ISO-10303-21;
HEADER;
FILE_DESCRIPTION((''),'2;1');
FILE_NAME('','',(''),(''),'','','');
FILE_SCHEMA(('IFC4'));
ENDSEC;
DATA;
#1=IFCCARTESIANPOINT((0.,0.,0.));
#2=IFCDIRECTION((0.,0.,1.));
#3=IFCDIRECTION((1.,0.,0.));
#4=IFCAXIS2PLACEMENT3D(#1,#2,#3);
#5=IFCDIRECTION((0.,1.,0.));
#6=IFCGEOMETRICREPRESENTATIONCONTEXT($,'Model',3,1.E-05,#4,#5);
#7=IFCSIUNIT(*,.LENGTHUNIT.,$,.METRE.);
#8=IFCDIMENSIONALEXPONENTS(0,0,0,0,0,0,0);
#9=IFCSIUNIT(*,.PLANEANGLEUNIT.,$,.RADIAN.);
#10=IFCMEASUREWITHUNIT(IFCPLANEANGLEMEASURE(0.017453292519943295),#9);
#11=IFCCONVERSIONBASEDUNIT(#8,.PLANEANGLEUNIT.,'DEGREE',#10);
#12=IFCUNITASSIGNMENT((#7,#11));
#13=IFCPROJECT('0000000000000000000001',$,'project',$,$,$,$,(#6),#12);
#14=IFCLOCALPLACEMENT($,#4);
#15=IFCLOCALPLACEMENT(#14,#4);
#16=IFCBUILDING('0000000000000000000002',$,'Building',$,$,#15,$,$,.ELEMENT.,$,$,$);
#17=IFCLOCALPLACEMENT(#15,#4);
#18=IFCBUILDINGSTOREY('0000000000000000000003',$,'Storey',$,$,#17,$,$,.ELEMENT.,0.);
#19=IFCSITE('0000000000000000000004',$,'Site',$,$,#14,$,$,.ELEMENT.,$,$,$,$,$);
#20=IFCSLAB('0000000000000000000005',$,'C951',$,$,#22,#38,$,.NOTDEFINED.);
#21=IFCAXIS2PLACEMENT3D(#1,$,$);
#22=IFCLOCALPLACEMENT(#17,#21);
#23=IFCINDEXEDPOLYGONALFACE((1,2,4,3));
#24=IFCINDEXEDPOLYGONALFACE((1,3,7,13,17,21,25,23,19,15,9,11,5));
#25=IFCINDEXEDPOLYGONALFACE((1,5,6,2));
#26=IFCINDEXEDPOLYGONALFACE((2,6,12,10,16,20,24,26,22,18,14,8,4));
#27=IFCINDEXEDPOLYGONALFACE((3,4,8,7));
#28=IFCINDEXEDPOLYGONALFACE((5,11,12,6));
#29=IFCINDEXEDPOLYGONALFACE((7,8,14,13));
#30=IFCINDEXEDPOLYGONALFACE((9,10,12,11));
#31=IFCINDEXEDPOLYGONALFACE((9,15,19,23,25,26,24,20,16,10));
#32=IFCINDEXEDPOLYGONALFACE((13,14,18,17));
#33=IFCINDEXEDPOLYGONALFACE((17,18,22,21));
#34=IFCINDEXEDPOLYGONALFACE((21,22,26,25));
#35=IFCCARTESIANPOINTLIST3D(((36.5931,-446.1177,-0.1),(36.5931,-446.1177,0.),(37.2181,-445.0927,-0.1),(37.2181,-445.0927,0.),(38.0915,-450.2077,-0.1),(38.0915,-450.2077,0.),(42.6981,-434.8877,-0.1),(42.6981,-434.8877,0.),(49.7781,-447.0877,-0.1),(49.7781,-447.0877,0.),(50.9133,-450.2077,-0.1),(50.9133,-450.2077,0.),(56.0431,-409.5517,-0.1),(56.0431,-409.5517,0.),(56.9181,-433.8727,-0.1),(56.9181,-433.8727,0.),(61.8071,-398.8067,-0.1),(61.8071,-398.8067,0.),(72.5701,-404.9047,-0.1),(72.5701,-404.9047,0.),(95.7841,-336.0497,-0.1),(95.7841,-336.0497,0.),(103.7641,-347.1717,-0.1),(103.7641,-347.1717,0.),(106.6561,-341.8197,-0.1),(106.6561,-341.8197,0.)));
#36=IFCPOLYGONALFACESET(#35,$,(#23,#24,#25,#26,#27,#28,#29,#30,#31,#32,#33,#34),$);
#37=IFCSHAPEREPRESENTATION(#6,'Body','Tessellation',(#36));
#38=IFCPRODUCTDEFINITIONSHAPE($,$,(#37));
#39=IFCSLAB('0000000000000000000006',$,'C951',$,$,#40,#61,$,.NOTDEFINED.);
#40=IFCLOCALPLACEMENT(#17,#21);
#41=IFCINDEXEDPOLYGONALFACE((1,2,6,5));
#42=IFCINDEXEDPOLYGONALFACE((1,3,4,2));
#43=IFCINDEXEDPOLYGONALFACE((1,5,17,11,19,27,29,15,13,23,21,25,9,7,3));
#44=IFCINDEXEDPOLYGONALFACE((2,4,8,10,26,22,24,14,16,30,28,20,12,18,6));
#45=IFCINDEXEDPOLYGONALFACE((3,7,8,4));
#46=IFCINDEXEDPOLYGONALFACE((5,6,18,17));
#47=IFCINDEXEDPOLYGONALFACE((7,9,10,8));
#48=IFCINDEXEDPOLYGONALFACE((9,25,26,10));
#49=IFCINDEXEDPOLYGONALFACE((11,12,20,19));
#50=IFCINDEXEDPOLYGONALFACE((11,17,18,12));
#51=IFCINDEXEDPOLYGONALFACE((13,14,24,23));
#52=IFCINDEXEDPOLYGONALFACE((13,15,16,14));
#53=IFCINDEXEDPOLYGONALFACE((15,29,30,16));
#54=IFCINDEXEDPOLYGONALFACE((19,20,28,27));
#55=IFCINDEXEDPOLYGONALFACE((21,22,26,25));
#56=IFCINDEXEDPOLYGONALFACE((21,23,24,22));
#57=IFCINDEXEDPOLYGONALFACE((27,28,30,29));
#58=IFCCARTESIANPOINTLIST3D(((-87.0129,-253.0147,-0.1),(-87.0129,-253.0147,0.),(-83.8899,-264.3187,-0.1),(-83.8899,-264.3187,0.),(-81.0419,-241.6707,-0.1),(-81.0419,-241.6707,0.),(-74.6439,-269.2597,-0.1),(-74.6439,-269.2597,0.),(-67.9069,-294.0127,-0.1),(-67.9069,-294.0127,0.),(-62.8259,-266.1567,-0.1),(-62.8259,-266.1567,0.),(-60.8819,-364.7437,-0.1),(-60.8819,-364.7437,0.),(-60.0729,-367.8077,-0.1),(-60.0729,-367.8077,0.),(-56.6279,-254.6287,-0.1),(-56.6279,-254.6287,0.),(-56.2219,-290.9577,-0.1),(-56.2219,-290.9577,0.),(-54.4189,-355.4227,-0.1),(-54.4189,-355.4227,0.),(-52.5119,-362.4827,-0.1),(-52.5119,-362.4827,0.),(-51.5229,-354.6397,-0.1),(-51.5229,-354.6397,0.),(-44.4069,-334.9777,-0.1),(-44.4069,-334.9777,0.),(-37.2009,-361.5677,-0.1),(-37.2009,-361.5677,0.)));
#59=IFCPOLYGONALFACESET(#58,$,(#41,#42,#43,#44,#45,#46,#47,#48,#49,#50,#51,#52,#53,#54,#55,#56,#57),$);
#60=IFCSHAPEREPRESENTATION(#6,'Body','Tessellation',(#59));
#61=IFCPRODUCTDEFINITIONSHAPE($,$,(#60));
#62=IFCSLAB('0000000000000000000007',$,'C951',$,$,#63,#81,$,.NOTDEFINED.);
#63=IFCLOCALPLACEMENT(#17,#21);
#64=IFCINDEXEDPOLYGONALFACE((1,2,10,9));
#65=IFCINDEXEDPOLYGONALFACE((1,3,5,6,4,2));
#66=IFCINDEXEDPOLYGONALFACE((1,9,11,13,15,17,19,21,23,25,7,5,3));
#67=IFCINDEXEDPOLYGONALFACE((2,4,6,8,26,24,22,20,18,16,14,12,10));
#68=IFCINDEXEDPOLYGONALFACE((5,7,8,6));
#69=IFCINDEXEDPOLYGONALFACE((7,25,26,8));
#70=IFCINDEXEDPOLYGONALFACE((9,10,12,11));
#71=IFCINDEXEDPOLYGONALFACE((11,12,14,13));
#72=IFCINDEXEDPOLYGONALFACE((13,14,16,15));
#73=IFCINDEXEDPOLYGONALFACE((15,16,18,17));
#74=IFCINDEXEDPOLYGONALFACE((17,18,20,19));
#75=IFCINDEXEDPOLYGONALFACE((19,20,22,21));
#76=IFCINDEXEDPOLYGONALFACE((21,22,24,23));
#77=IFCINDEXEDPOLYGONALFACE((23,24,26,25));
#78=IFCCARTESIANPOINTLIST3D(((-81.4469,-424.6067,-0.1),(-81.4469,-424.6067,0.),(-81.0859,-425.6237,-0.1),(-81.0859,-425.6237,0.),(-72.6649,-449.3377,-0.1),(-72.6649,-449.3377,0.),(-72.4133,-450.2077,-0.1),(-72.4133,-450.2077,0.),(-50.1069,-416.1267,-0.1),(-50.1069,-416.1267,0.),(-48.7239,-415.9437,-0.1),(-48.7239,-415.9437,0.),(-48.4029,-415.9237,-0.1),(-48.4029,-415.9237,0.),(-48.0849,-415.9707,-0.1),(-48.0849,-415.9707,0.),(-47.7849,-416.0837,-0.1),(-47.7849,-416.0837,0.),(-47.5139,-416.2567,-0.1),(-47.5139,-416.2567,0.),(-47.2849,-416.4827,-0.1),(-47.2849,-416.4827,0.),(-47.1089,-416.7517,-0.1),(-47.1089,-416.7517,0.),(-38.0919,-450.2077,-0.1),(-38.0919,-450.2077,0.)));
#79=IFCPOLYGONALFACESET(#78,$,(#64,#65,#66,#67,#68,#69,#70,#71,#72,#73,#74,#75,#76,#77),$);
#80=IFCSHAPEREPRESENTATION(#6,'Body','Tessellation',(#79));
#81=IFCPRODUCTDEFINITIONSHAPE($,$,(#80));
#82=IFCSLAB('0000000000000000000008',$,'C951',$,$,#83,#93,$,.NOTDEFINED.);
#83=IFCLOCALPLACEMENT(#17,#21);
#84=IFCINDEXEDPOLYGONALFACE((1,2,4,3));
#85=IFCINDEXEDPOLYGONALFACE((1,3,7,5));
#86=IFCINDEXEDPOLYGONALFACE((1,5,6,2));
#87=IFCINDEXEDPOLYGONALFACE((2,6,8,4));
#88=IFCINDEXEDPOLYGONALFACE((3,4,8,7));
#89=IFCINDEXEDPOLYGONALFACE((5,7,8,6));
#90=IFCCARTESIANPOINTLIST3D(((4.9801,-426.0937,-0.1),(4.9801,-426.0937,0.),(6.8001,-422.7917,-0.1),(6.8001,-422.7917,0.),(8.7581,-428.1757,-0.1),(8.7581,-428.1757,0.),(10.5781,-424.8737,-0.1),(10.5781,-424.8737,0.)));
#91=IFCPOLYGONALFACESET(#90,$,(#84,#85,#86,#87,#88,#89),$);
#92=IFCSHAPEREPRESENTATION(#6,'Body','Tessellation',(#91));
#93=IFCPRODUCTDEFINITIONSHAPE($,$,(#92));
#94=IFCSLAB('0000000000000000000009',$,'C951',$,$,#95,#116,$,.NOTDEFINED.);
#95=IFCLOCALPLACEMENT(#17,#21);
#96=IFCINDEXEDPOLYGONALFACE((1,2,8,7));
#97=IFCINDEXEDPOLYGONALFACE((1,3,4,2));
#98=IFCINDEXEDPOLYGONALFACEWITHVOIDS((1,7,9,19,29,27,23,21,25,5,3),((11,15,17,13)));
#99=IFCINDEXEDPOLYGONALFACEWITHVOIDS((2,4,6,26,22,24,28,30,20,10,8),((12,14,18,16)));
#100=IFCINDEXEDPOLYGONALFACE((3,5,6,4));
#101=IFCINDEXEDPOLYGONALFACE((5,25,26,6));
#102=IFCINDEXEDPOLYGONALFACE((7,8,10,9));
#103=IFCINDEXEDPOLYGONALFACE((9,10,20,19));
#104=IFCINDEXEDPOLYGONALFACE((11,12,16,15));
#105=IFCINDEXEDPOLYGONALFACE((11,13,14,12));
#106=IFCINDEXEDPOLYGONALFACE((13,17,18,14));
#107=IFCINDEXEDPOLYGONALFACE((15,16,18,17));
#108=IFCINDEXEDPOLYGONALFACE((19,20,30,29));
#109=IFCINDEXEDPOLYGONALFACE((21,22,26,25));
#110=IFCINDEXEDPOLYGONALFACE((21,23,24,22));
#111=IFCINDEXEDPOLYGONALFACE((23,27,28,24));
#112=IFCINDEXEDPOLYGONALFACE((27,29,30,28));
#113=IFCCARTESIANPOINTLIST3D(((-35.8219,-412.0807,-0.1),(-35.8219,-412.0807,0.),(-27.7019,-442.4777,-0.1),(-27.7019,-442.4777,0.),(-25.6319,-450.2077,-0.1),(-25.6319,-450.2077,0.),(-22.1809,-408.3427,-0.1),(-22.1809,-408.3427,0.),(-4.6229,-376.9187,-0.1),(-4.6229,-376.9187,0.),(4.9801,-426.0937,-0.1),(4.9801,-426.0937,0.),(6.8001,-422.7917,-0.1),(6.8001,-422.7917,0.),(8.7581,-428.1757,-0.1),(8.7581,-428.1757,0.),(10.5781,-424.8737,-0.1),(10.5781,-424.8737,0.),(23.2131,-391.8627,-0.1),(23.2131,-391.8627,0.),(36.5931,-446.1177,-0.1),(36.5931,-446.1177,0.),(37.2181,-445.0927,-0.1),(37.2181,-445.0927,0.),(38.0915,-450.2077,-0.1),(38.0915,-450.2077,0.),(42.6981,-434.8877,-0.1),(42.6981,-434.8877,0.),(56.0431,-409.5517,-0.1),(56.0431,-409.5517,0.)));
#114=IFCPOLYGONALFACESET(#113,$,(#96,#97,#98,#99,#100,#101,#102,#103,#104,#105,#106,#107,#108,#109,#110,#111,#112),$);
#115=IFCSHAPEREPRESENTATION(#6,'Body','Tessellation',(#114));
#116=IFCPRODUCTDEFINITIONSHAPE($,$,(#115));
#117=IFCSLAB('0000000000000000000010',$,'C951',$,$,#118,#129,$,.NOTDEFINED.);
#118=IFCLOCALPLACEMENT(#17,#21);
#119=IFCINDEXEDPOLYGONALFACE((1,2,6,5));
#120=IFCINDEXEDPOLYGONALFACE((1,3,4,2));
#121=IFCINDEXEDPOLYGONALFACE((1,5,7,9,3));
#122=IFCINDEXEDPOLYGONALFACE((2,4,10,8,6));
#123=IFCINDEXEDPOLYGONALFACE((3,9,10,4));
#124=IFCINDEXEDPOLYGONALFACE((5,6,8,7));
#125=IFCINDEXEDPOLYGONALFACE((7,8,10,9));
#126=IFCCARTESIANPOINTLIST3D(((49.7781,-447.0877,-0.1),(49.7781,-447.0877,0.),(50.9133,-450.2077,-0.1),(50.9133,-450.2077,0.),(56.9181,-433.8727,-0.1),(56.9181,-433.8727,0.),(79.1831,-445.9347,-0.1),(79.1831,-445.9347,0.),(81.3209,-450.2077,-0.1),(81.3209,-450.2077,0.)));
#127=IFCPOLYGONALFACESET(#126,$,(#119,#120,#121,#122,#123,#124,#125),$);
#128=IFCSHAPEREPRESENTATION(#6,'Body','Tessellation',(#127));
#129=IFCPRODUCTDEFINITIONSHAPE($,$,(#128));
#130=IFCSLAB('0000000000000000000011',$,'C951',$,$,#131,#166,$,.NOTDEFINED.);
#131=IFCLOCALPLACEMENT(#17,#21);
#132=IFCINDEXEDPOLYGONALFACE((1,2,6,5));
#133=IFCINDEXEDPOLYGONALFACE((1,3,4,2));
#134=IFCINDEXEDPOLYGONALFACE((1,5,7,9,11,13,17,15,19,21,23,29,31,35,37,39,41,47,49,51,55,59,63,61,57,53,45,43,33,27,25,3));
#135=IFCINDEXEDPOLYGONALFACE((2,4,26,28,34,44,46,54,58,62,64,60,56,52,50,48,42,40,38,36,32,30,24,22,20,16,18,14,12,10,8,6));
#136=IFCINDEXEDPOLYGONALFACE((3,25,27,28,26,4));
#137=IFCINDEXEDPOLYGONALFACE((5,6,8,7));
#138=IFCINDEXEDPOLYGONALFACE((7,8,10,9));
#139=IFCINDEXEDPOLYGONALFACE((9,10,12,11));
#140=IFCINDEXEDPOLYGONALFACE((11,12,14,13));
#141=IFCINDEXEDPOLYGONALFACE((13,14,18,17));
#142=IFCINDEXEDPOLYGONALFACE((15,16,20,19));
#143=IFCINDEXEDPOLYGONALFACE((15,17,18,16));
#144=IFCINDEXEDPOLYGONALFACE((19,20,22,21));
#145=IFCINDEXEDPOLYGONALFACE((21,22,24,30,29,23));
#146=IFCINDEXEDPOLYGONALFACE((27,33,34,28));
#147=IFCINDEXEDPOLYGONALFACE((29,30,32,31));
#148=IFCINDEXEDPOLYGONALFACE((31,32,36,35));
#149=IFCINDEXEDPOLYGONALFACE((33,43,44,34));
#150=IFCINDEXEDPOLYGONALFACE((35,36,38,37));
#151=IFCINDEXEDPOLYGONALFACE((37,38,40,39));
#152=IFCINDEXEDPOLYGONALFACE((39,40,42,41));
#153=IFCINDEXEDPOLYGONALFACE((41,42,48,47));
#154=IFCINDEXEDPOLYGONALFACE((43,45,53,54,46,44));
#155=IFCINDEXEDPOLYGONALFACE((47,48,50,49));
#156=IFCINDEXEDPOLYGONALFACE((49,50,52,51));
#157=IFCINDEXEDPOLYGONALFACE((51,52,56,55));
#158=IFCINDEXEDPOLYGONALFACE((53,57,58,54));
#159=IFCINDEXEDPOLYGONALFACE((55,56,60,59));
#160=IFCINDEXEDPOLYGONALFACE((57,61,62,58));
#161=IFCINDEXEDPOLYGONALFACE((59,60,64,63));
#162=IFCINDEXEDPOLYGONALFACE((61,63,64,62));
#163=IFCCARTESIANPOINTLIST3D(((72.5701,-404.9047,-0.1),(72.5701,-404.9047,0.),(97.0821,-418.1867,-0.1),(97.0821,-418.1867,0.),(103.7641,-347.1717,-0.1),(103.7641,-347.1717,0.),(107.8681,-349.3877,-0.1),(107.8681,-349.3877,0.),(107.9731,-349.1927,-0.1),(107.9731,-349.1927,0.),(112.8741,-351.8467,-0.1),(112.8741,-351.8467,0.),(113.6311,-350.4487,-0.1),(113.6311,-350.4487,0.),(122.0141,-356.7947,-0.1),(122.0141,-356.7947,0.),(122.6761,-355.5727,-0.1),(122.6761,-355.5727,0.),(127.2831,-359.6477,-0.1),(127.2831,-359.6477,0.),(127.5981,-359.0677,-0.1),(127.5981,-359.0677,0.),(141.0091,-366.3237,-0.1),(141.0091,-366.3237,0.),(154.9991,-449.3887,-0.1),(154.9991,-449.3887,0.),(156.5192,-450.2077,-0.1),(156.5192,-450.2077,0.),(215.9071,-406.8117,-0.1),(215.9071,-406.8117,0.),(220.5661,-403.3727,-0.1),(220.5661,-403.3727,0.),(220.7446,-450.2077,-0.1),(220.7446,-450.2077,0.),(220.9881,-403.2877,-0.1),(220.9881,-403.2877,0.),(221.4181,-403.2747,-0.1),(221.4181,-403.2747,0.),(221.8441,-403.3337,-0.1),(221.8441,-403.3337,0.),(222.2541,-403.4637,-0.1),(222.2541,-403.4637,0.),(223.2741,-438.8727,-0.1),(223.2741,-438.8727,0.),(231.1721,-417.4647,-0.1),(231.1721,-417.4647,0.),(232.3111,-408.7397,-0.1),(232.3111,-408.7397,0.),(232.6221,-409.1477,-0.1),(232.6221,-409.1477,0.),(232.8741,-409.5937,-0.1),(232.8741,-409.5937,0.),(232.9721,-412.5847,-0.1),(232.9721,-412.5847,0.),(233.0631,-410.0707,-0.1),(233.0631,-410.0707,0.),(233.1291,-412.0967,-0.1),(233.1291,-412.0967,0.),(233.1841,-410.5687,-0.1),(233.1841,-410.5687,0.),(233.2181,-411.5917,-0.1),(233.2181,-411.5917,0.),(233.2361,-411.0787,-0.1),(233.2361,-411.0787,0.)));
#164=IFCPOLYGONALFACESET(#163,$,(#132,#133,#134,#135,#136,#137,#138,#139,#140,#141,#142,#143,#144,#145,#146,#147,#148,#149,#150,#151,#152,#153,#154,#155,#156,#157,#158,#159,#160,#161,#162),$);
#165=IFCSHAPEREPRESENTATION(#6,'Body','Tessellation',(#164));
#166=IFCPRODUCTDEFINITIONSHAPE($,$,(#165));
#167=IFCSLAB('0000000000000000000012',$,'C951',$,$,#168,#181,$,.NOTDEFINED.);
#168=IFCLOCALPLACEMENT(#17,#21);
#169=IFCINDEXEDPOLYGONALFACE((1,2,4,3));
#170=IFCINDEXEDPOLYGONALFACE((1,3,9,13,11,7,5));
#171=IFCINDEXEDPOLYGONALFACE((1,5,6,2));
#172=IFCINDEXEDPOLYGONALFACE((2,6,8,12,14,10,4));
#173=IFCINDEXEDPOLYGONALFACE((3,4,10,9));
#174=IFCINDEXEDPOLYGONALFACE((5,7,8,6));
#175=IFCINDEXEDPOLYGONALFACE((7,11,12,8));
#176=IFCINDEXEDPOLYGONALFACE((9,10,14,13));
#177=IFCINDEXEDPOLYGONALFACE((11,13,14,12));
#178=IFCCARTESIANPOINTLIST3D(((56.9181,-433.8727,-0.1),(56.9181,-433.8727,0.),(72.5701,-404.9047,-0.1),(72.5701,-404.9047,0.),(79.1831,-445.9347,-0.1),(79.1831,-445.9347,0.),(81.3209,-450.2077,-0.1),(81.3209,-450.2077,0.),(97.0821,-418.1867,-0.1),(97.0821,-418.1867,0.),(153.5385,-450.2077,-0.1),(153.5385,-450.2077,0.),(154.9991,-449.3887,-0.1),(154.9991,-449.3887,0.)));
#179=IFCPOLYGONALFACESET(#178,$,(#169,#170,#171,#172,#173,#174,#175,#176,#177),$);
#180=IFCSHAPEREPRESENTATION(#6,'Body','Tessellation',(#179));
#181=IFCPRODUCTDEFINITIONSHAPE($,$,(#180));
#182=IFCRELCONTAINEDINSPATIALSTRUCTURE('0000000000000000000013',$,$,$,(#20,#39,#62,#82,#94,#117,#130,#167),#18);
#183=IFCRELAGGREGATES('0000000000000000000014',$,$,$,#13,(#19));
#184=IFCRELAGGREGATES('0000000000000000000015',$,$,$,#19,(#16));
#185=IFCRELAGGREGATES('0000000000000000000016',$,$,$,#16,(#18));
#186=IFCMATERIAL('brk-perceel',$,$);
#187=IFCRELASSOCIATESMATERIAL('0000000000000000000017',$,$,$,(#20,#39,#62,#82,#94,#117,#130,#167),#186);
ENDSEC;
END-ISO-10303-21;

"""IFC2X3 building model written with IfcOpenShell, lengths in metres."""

from ifc_helpers import new_model, entity, si_unit, converted_unit, direction, frame, origin_with_axes, place, context, project, spatial, polyline, outline, extrude, material, element, save


model = new_model("IFC2X3")

# Units and contexts
model_context = context("Model", 3, precision=1e-05, world=origin_with_axes(), true_north=direction((0.0, 1.0, 0.0)))
ifc_project = project(units=[si_unit("LENGTHUNIT", "METRE"), converted_unit("PLANEANGLEUNIT", "DEGREE", entity("IfcPlaneAngleMeasure", 0.017453292519943295), si_unit("PLANEANGLEUNIT", "RADIAN"), dimensions=[0, 0, 0, 0, 0, 0, 0])], contexts=[model_context])

# Site, building, storey
site_placement = place(None, origin_with_axes())
site = spatial("IfcSite", under=ifc_project, at=site_placement, Name="Site", CompositionType="ELEMENT")
building_placement = place(site_placement, origin_with_axes())
building = spatial("IfcBuilding", under=site, at=building_placement, Name="Building", CompositionType="ELEMENT")
storey_placement = place(building_placement, origin_with_axes())
storey = spatial("IfcBuildingStorey", under=building, at=storey_placement, Name="Storey", CompositionType="ELEMENT", Elevation=0.0)

# Slabs
ifc_material = material(Name="brk-perceel")
slab_1_placement = place(storey_placement, frame((0.0, 0.0, -0.1), z_axis=(0.0, 0.0, 1.0), x_axis=(1.0, 0.0, 0.0)))
element("IfcSlab", 1, at=slab_1_placement, inside=storey, material=ifc_material, Name="C951", PredefinedType="NOTDEFINED", context=model_context, shape_type="SweptSolid", body=[
    extrude(outline(polyline([(36.5931, -446.1177), (37.2181, -445.0927), (42.6981, -434.8877), (56.0431, -409.5517), (61.8071, -398.8067), (95.7841, -336.0497), (106.6561, -341.8197), (103.7641, -347.1717), (72.5701, -404.9047), (56.9181, -433.8727), (49.7781, -447.0877), (50.9133, -450.2077), (38.0915, -450.2077), (36.5931, -446.1177)])), origin_with_axes(), (0.0, 0.0, 1.0), 0.1),
])
slab_2_placement = place(storey_placement, frame((0.0, 0.0, -0.1), z_axis=(0.0, 0.0, 1.0), x_axis=(1.0, 0.0, 0.0)))
element("IfcSlab", 2, at=slab_2_placement, inside=storey, material=ifc_material, Name="C951", PredefinedType="NOTDEFINED", context=model_context, shape_type="SweptSolid", body=[
    extrude(outline(polyline([(-81.0419, -241.6707), (-56.6279, -254.6287), (-62.8259, -266.1567), (-56.2219, -290.9577), (-44.4069, -334.9777), (-37.2009, -361.5677), (-60.0729, -367.8077), (-60.8819, -364.7437), (-52.5119, -362.4827), (-54.4189, -355.4227), (-51.5229, -354.6397), (-67.9069, -294.0127), (-74.6439, -269.2597), (-83.8899, -264.3187), (-87.0129, -253.0147), (-81.0419, -241.6707)])), origin_with_axes(), (0.0, 0.0, 1.0), 0.1),
])
slab_3_placement = place(storey_placement, frame((0.0, 0.0, -0.1), z_axis=(0.0, 0.0, 1.0), x_axis=(1.0, 0.0, 0.0)))
element("IfcSlab", 3, at=slab_3_placement, inside=storey, material=ifc_material, Name="C951", PredefinedType="NOTDEFINED", context=model_context, shape_type="SweptSolid", body=[
    extrude(outline(polyline([(-72.6649, -449.3377), (-81.0859, -425.6237), (-81.4469, -424.6067), (-50.1069, -416.1267), (-48.7239, -415.9437), (-48.4029, -415.9237), (-48.0849, -415.9707), (-47.7849, -416.0837), (-47.5139, -416.2567), (-47.2849, -416.4827), (-47.1089, -416.7517), (-38.0919, -450.2077), (-72.4133, -450.2077), (-72.6649, -449.3377)])), origin_with_axes(), (0.0, 0.0, 1.0), 0.1),
])
slab_4_placement = place(storey_placement, frame((0.0, 0.0, -0.1), z_axis=(0.0, 0.0, 1.0), x_axis=(1.0, 0.0, 0.0)))
element("IfcSlab", 4, at=slab_4_placement, inside=storey, material=ifc_material, Name="C951", PredefinedType="NOTDEFINED", context=model_context, shape_type="SweptSolid", body=[
    extrude(outline(polyline([(8.7581, -428.1757), (4.9801, -426.0937), (6.8001, -422.7917), (10.5781, -424.8737), (8.7581, -428.1757)])), origin_with_axes(), (0.0, 0.0, 1.0), 0.1),
])
slab_5_placement = place(storey_placement, frame((0.0, 0.0, -0.1), z_axis=(0.0, 0.0, 1.0), x_axis=(1.0, 0.0, 0.0)))
element("IfcSlab", 5, at=slab_5_placement, inside=storey, material=ifc_material, Name="C951", PredefinedType="NOTDEFINED", context=model_context, shape_type="SweptSolid", body=[
    extrude(outline(polyline([(-27.7019, -442.4777), (-35.8219, -412.0807), (-22.1809, -408.3427), (-4.6229, -376.9187), (23.2131, -391.8627), (56.0431, -409.5517), (42.6981, -434.8877), (37.2181, -445.0927), (36.5931, -446.1177), (38.0915, -450.2077), (-25.6319, -450.2077), (-27.7019, -442.4777)]), holes=[polyline([(8.7581, -428.1757), (10.5781, -424.8737), (6.8001, -422.7917), (4.9801, -426.0937), (8.7581, -428.1757)])]), origin_with_axes(), (0.0, 0.0, 1.0), 0.1),
])
slab_6_placement = place(storey_placement, frame((0.0, 0.0, -0.1), z_axis=(0.0, 0.0, 1.0), x_axis=(1.0, 0.0, 0.0)))
element("IfcSlab", 6, at=slab_6_placement, inside=storey, material=ifc_material, Name="C951", PredefinedType="NOTDEFINED", context=model_context, shape_type="SweptSolid", body=[
    extrude(outline(polyline([(49.7781, -447.0877), (56.9181, -433.8727), (79.1831, -445.9347), (81.3209, -450.2077), (50.9133, -450.2077), (49.7781, -447.0877)])), origin_with_axes(), (0.0, 0.0, 1.0), 0.1),
])
slab_7_placement = place(storey_placement, frame((0.0, 0.0, -0.1), z_axis=(0.0, 0.0, 1.0), x_axis=(1.0, 0.0, 0.0)))
element("IfcSlab", 7, at=slab_7_placement, inside=storey, material=ifc_material, Name="C951", PredefinedType="NOTDEFINED", context=model_context, shape_type="SweptSolid", body=[
    extrude(outline(polyline([(154.9991, -449.3887), (97.0821, -418.1867), (72.5701, -404.9047), (103.7641, -347.1717), (107.8681, -349.3877), (107.9731, -349.1927), (112.8741, -351.8467), (113.6311, -350.4487), (122.6761, -355.5727), (122.0141, -356.7947), (127.2831, -359.6477), (127.5981, -359.0677), (141.0091, -366.3237), (215.9071, -406.8117), (220.5661, -403.3727), (220.9881, -403.2877), (221.4181, -403.2747), (221.8441, -403.3337), (222.2541, -403.4637), (232.3111, -408.7397), (232.6221, -409.1477), (232.8741, -409.5937), (233.0631, -410.0707), (233.1841, -410.5687), (233.2361, -411.0787), (233.2181, -411.5917), (233.1291, -412.0967), (232.9721, -412.5847), (231.1721, -417.4647), (223.2741, -438.8727), (220.7446, -450.2077), (156.5192, -450.2077), (154.9991, -449.3887)])), origin_with_axes(), (0.0, 0.0, 1.0), 0.1),
])
slab_8_placement = place(storey_placement, frame((0.0, 0.0, -0.1), z_axis=(0.0, 0.0, 1.0), x_axis=(1.0, 0.0, 0.0)))
element("IfcSlab", 8, at=slab_8_placement, inside=storey, material=ifc_material, Name="C951", PredefinedType="NOTDEFINED", context=model_context, shape_type="SweptSolid", body=[
    extrude(outline(polyline([(79.1831, -445.9347), (56.9181, -433.8727), (72.5701, -404.9047), (97.0821, -418.1867), (154.9991, -449.3887), (153.5385, -450.2077), (81.3209, -450.2077), (79.1831, -445.9347)])), origin_with_axes(), (0.0, 0.0, 1.0), 0.1),
])

save(model, "model.ifc")
